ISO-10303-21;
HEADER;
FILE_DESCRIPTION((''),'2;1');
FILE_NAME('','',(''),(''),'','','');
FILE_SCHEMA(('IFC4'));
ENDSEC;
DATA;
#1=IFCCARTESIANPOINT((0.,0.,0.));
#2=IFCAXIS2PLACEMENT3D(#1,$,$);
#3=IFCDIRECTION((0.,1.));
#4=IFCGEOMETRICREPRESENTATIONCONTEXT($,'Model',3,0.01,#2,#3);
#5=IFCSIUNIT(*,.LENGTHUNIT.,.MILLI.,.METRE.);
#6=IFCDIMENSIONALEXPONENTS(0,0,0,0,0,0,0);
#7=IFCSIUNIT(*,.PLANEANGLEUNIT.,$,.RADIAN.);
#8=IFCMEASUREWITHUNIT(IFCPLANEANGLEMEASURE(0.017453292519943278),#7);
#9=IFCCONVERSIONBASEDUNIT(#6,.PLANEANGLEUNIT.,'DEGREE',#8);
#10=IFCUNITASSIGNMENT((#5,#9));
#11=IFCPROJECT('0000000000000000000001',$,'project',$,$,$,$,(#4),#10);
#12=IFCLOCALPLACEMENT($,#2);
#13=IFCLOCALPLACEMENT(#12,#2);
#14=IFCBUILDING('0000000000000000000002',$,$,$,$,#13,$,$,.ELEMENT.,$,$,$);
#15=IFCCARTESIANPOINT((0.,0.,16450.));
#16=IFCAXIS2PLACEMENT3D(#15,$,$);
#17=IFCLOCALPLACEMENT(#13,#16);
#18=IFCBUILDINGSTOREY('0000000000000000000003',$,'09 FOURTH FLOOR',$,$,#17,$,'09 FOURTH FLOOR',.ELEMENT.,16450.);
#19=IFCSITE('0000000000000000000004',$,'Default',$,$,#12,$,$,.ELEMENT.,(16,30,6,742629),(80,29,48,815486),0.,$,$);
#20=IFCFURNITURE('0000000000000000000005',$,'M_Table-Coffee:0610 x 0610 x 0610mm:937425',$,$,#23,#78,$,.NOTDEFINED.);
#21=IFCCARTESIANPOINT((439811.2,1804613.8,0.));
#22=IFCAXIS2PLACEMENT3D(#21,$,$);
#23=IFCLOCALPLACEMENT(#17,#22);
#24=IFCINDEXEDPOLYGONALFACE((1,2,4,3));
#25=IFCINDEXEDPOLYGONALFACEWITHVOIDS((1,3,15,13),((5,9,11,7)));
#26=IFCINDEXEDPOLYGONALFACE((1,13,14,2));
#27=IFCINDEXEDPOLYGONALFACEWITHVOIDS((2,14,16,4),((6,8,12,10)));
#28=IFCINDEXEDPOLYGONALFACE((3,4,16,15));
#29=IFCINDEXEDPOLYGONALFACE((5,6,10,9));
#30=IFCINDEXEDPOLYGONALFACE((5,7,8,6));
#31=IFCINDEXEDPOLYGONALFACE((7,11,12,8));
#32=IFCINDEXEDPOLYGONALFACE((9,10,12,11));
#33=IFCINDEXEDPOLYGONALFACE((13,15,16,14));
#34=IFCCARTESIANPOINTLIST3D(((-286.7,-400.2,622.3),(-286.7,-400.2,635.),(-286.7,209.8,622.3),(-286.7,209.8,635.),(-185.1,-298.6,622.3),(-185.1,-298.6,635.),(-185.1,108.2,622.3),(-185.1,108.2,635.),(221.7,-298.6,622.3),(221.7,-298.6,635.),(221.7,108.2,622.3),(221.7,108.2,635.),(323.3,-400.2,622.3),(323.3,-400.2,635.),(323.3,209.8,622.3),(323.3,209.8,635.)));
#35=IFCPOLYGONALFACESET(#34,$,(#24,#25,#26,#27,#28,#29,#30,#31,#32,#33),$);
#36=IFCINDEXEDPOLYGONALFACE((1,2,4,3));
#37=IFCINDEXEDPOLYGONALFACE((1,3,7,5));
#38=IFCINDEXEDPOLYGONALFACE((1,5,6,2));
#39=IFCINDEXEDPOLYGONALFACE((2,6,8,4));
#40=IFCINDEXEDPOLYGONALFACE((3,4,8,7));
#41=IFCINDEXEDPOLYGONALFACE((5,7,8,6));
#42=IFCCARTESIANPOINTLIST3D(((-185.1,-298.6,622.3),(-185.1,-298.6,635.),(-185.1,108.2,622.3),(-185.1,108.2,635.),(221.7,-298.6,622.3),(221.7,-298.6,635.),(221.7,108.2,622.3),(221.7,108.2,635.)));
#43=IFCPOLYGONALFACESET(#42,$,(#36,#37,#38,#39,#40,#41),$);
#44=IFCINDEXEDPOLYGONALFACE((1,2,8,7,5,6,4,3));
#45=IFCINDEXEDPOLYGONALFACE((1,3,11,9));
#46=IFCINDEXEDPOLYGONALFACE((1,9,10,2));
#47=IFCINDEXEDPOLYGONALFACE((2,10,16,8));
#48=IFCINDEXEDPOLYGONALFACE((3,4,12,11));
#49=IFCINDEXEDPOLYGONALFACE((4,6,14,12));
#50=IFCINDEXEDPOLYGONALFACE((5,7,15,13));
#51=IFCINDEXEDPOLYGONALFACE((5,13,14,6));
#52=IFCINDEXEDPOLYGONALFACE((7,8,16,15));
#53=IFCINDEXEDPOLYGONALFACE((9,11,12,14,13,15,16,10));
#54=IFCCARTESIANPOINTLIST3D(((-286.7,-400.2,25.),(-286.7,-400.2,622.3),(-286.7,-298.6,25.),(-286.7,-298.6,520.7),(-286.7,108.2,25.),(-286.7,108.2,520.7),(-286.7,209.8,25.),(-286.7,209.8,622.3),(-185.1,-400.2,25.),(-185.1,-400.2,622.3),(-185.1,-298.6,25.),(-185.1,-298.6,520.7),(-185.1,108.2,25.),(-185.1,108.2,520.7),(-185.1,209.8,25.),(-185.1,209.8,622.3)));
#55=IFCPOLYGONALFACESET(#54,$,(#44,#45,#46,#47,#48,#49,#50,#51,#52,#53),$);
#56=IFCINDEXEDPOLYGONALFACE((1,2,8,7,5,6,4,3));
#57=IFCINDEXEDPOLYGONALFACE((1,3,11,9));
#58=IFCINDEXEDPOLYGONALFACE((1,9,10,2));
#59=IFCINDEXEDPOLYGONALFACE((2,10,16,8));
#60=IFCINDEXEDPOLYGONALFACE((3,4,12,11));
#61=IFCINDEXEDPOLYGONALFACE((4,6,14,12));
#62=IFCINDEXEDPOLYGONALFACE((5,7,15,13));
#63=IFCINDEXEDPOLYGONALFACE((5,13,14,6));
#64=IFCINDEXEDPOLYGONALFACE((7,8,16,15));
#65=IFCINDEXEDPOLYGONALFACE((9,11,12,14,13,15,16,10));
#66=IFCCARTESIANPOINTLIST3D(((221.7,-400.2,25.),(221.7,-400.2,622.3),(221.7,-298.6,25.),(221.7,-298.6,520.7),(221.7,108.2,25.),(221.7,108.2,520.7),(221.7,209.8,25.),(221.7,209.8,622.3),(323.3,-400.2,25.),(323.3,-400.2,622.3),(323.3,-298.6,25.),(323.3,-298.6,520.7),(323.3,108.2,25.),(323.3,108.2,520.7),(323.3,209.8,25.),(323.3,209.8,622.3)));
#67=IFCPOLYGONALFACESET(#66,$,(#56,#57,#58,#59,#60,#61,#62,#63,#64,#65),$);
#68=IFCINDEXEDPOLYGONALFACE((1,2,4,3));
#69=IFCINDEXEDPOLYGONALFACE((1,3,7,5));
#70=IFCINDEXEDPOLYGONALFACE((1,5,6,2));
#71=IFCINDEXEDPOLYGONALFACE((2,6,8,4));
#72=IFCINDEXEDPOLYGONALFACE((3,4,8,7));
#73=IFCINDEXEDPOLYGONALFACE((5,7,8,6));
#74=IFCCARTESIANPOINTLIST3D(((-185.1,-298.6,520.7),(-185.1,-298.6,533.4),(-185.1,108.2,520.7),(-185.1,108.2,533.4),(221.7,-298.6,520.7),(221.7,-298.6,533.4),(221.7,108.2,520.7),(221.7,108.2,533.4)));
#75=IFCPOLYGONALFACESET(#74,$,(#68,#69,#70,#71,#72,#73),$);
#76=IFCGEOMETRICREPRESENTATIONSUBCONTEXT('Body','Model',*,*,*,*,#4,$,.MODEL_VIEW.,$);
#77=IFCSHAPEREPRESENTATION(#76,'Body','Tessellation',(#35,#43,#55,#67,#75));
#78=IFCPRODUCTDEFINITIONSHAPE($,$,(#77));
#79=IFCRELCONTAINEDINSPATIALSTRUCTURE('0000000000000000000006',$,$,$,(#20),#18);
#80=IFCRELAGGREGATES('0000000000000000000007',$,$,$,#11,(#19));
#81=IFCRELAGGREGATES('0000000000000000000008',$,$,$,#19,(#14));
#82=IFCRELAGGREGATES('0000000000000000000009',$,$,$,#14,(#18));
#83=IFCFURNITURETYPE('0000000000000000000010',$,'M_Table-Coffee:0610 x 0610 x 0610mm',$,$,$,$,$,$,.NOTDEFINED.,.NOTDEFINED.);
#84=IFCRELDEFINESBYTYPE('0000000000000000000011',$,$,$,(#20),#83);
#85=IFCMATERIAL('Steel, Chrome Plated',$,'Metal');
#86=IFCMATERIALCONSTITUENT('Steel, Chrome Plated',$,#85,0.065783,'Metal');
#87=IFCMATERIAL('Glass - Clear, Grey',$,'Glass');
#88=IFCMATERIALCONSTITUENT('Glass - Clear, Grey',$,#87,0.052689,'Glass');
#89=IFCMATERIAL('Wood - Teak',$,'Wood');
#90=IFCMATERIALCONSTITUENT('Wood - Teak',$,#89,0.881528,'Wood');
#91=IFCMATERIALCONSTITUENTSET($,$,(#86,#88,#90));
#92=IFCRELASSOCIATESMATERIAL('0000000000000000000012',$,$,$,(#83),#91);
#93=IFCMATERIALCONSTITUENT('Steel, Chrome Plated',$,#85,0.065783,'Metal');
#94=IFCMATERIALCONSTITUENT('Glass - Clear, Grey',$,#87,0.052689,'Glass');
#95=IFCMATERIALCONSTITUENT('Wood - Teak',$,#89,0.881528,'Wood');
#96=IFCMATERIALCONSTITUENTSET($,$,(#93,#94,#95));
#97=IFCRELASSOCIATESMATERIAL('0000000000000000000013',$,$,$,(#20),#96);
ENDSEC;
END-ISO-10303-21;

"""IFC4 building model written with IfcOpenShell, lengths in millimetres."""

from ifc_helpers import new_model, entity, si_unit, converted_unit, direction, frame, origin, place, context, subcontext, project, spatial, indexed_curve, outline, extrude, source, transform, mapped, material, constituent, constituent_set, type_object, type_shapes, element, save


model = new_model("IFC4")

# Units and contexts
model_context = context("Model", 3, precision=0.01, world=origin(), true_north=direction((0.0, 1.0)))
body_context = subcontext(model_context, "Body", "Model", "MODEL_VIEW")
ifc_project = project(units=[si_unit("LENGTHUNIT", "METRE", prefix="MILLI"), converted_unit("PLANEANGLEUNIT", "DEGREE", entity("IfcPlaneAngleMeasure", 0.017453292519943278), si_unit("PLANEANGLEUNIT", "RADIAN"), dimensions=[0, 0, 0, 0, 0, 0, 0])], contexts=[model_context])

# Site, building, storey
site_placement = place(None, origin())
site = spatial("IfcSite", under=ifc_project, at=site_placement, Name="Default", CompositionType="ELEMENT", RefLatitude=(16, 30, 6, 742629), RefLongitude=(80, 29, 48, 815486), RefElevation=0.0)
building_placement = place(site_placement, origin())
building = spatial("IfcBuilding", under=site, at=building_placement, CompositionType="ELEMENT")
storey_placement = place(building_placement, frame((0.0, 0.0, 16450.0)))
storey = spatial("IfcBuildingStorey", under=building, at=storey_placement, Name="09 FOURTH FLOOR", LongName="09 FOURTH FLOOR", CompositionType="ELEMENT", Elevation=16450.0)

# Furniture
ifc_material_1 = material(Name="Steel, Chrome Plated", Category="Metal")
ifc_material_2 = material(Name="Glass - Clear, Grey", Category="Glass")
ifc_material_3 = material(Name="Wood - Teak", Category="Wood")
ifc_constituent_1 = constituent(ifc_material_1, Name="Steel, Chrome Plated", Category="Metal", fraction=0.065783)
ifc_constituent_2 = constituent(ifc_material_2, Name="Glass - Clear, Grey", Category="Glass", fraction=0.052689)
ifc_constituent_3 = constituent(ifc_material_3, Name="Wood - Teak", Category="Wood", fraction=0.881528)
ifc_constituent_set_1 = constituent_set(constituents=[ifc_constituent_1, ifc_constituent_2, ifc_constituent_3])
ifc_constituent_4 = constituent(ifc_material_1, Name="Steel, Chrome Plated", Category="Metal", fraction=0.065783)
ifc_constituent_5 = constituent(ifc_material_2, Name="Glass - Clear, Grey", Category="Glass", fraction=0.052689)
ifc_constituent_6 = constituent(ifc_material_3, Name="Wood - Teak", Category="Wood", fraction=0.881528)
ifc_constituent_set_2 = constituent_set(constituents=[ifc_constituent_4, ifc_constituent_5, ifc_constituent_6])
furniture_type_1 = type_object("IfcFurnitureType", Name="M_Table-Coffee:0610 x 0610 x 0610mm", AssemblyPlace="NOTDEFINED", PredefinedType="NOTDEFINED", material=ifc_constituent_set_2)
shared_shape_1 = source(origin(), body_context, "Body", "SweptSolid", [
    extrude(outline(indexed_curve([(-305.0, -305.0), (305.0, -305.0), (305.0, 305.0), (-305.0, 305.0), (-305.0, -305.0)], self_intersect=False), holes=[indexed_curve([(-203.4, -203.4), (-203.4, 203.4), (203.4, 203.4), (203.4, -203.4), (-203.4, -203.4)], self_intersect=False)]), frame((18.3, -95.2, 622.3), z_axis=(0.0, 0.0, 1.0), x_axis=(0.0, 1.0, 0.0)), (0.0, 0.0, 1.0), 12.7),
    extrude(outline(indexed_curve([(-203.4, -203.4), (203.4, -203.4), (203.4, 203.4), (-203.4, 203.4), (-203.4, -203.4)], self_intersect=False)), frame((18.3, -95.2, 622.3), z_axis=(0.0, 0.0, 1.0), x_axis=(0.0, 1.0, 0.0)), (0.0, 0.0, 1.0), 12.7),
    extrude(outline(indexed_curve([(-324.1, -305.0), (273.3, -305.0), (273.3, -203.4), (-222.4, -203.4), (-222.4, 203.4), (273.3, 203.4), (273.3, 305.0), (-324.1, 305.0), (-324.1, -305.0)], self_intersect=False)), frame((-286.7, -95.2, 298.3), z_axis=(1.0, 0.0, 0.0), x_axis=(0.0, 0.0, -1.0)), (0.0, 0.0, 1.0), 101.6),
    extrude(outline(indexed_curve([(-305.0, -273.2), (-203.4, -273.2), (-203.4, 222.5), (203.4, 222.5), (203.4, -273.2), (305.0, -273.2), (305.0, 324.0), (-305.0, 324.0), (-305.0, -273.2)], self_intersect=False)), frame((221.7, -95.2, 298.2), z_axis=(1.0, 0.0, 0.0), x_axis=(0.0, 1.0, 0.0)), (0.0, 0.0, 1.0), 101.6),
    extrude(outline(indexed_curve([(-203.4, -203.4), (203.4, -203.4), (203.4, 203.4), (-203.4, 203.4), (-203.4, -203.4)], self_intersect=False)), frame((18.3, -95.2, 520.7), z_axis=(0.0, 0.0, 1.0), x_axis=(0.0, 1.0, 0.0)), (0.0, 0.0, 1.0), 12.7),
])
type_shapes(furniture_type_1, [shared_shape_1])
furniture_1_placement = place(storey_placement, frame((439811.2, 1804613.8, 0.0)))
element("IfcFurniture", 1, at=furniture_1_placement, inside=storey, type_object=furniture_type_1, material=ifc_constituent_set_1, Name="M_Table-Coffee:0610 x 0610 x 0610mm:937425", PredefinedType="NOTDEFINED", context=body_context, shape_type="MappedRepresentation", body=[
    mapped(shared_shape_1, transform((0.0, 0.0, 0.0), scale=1.0)),
])

save(model, "model.ifc")
